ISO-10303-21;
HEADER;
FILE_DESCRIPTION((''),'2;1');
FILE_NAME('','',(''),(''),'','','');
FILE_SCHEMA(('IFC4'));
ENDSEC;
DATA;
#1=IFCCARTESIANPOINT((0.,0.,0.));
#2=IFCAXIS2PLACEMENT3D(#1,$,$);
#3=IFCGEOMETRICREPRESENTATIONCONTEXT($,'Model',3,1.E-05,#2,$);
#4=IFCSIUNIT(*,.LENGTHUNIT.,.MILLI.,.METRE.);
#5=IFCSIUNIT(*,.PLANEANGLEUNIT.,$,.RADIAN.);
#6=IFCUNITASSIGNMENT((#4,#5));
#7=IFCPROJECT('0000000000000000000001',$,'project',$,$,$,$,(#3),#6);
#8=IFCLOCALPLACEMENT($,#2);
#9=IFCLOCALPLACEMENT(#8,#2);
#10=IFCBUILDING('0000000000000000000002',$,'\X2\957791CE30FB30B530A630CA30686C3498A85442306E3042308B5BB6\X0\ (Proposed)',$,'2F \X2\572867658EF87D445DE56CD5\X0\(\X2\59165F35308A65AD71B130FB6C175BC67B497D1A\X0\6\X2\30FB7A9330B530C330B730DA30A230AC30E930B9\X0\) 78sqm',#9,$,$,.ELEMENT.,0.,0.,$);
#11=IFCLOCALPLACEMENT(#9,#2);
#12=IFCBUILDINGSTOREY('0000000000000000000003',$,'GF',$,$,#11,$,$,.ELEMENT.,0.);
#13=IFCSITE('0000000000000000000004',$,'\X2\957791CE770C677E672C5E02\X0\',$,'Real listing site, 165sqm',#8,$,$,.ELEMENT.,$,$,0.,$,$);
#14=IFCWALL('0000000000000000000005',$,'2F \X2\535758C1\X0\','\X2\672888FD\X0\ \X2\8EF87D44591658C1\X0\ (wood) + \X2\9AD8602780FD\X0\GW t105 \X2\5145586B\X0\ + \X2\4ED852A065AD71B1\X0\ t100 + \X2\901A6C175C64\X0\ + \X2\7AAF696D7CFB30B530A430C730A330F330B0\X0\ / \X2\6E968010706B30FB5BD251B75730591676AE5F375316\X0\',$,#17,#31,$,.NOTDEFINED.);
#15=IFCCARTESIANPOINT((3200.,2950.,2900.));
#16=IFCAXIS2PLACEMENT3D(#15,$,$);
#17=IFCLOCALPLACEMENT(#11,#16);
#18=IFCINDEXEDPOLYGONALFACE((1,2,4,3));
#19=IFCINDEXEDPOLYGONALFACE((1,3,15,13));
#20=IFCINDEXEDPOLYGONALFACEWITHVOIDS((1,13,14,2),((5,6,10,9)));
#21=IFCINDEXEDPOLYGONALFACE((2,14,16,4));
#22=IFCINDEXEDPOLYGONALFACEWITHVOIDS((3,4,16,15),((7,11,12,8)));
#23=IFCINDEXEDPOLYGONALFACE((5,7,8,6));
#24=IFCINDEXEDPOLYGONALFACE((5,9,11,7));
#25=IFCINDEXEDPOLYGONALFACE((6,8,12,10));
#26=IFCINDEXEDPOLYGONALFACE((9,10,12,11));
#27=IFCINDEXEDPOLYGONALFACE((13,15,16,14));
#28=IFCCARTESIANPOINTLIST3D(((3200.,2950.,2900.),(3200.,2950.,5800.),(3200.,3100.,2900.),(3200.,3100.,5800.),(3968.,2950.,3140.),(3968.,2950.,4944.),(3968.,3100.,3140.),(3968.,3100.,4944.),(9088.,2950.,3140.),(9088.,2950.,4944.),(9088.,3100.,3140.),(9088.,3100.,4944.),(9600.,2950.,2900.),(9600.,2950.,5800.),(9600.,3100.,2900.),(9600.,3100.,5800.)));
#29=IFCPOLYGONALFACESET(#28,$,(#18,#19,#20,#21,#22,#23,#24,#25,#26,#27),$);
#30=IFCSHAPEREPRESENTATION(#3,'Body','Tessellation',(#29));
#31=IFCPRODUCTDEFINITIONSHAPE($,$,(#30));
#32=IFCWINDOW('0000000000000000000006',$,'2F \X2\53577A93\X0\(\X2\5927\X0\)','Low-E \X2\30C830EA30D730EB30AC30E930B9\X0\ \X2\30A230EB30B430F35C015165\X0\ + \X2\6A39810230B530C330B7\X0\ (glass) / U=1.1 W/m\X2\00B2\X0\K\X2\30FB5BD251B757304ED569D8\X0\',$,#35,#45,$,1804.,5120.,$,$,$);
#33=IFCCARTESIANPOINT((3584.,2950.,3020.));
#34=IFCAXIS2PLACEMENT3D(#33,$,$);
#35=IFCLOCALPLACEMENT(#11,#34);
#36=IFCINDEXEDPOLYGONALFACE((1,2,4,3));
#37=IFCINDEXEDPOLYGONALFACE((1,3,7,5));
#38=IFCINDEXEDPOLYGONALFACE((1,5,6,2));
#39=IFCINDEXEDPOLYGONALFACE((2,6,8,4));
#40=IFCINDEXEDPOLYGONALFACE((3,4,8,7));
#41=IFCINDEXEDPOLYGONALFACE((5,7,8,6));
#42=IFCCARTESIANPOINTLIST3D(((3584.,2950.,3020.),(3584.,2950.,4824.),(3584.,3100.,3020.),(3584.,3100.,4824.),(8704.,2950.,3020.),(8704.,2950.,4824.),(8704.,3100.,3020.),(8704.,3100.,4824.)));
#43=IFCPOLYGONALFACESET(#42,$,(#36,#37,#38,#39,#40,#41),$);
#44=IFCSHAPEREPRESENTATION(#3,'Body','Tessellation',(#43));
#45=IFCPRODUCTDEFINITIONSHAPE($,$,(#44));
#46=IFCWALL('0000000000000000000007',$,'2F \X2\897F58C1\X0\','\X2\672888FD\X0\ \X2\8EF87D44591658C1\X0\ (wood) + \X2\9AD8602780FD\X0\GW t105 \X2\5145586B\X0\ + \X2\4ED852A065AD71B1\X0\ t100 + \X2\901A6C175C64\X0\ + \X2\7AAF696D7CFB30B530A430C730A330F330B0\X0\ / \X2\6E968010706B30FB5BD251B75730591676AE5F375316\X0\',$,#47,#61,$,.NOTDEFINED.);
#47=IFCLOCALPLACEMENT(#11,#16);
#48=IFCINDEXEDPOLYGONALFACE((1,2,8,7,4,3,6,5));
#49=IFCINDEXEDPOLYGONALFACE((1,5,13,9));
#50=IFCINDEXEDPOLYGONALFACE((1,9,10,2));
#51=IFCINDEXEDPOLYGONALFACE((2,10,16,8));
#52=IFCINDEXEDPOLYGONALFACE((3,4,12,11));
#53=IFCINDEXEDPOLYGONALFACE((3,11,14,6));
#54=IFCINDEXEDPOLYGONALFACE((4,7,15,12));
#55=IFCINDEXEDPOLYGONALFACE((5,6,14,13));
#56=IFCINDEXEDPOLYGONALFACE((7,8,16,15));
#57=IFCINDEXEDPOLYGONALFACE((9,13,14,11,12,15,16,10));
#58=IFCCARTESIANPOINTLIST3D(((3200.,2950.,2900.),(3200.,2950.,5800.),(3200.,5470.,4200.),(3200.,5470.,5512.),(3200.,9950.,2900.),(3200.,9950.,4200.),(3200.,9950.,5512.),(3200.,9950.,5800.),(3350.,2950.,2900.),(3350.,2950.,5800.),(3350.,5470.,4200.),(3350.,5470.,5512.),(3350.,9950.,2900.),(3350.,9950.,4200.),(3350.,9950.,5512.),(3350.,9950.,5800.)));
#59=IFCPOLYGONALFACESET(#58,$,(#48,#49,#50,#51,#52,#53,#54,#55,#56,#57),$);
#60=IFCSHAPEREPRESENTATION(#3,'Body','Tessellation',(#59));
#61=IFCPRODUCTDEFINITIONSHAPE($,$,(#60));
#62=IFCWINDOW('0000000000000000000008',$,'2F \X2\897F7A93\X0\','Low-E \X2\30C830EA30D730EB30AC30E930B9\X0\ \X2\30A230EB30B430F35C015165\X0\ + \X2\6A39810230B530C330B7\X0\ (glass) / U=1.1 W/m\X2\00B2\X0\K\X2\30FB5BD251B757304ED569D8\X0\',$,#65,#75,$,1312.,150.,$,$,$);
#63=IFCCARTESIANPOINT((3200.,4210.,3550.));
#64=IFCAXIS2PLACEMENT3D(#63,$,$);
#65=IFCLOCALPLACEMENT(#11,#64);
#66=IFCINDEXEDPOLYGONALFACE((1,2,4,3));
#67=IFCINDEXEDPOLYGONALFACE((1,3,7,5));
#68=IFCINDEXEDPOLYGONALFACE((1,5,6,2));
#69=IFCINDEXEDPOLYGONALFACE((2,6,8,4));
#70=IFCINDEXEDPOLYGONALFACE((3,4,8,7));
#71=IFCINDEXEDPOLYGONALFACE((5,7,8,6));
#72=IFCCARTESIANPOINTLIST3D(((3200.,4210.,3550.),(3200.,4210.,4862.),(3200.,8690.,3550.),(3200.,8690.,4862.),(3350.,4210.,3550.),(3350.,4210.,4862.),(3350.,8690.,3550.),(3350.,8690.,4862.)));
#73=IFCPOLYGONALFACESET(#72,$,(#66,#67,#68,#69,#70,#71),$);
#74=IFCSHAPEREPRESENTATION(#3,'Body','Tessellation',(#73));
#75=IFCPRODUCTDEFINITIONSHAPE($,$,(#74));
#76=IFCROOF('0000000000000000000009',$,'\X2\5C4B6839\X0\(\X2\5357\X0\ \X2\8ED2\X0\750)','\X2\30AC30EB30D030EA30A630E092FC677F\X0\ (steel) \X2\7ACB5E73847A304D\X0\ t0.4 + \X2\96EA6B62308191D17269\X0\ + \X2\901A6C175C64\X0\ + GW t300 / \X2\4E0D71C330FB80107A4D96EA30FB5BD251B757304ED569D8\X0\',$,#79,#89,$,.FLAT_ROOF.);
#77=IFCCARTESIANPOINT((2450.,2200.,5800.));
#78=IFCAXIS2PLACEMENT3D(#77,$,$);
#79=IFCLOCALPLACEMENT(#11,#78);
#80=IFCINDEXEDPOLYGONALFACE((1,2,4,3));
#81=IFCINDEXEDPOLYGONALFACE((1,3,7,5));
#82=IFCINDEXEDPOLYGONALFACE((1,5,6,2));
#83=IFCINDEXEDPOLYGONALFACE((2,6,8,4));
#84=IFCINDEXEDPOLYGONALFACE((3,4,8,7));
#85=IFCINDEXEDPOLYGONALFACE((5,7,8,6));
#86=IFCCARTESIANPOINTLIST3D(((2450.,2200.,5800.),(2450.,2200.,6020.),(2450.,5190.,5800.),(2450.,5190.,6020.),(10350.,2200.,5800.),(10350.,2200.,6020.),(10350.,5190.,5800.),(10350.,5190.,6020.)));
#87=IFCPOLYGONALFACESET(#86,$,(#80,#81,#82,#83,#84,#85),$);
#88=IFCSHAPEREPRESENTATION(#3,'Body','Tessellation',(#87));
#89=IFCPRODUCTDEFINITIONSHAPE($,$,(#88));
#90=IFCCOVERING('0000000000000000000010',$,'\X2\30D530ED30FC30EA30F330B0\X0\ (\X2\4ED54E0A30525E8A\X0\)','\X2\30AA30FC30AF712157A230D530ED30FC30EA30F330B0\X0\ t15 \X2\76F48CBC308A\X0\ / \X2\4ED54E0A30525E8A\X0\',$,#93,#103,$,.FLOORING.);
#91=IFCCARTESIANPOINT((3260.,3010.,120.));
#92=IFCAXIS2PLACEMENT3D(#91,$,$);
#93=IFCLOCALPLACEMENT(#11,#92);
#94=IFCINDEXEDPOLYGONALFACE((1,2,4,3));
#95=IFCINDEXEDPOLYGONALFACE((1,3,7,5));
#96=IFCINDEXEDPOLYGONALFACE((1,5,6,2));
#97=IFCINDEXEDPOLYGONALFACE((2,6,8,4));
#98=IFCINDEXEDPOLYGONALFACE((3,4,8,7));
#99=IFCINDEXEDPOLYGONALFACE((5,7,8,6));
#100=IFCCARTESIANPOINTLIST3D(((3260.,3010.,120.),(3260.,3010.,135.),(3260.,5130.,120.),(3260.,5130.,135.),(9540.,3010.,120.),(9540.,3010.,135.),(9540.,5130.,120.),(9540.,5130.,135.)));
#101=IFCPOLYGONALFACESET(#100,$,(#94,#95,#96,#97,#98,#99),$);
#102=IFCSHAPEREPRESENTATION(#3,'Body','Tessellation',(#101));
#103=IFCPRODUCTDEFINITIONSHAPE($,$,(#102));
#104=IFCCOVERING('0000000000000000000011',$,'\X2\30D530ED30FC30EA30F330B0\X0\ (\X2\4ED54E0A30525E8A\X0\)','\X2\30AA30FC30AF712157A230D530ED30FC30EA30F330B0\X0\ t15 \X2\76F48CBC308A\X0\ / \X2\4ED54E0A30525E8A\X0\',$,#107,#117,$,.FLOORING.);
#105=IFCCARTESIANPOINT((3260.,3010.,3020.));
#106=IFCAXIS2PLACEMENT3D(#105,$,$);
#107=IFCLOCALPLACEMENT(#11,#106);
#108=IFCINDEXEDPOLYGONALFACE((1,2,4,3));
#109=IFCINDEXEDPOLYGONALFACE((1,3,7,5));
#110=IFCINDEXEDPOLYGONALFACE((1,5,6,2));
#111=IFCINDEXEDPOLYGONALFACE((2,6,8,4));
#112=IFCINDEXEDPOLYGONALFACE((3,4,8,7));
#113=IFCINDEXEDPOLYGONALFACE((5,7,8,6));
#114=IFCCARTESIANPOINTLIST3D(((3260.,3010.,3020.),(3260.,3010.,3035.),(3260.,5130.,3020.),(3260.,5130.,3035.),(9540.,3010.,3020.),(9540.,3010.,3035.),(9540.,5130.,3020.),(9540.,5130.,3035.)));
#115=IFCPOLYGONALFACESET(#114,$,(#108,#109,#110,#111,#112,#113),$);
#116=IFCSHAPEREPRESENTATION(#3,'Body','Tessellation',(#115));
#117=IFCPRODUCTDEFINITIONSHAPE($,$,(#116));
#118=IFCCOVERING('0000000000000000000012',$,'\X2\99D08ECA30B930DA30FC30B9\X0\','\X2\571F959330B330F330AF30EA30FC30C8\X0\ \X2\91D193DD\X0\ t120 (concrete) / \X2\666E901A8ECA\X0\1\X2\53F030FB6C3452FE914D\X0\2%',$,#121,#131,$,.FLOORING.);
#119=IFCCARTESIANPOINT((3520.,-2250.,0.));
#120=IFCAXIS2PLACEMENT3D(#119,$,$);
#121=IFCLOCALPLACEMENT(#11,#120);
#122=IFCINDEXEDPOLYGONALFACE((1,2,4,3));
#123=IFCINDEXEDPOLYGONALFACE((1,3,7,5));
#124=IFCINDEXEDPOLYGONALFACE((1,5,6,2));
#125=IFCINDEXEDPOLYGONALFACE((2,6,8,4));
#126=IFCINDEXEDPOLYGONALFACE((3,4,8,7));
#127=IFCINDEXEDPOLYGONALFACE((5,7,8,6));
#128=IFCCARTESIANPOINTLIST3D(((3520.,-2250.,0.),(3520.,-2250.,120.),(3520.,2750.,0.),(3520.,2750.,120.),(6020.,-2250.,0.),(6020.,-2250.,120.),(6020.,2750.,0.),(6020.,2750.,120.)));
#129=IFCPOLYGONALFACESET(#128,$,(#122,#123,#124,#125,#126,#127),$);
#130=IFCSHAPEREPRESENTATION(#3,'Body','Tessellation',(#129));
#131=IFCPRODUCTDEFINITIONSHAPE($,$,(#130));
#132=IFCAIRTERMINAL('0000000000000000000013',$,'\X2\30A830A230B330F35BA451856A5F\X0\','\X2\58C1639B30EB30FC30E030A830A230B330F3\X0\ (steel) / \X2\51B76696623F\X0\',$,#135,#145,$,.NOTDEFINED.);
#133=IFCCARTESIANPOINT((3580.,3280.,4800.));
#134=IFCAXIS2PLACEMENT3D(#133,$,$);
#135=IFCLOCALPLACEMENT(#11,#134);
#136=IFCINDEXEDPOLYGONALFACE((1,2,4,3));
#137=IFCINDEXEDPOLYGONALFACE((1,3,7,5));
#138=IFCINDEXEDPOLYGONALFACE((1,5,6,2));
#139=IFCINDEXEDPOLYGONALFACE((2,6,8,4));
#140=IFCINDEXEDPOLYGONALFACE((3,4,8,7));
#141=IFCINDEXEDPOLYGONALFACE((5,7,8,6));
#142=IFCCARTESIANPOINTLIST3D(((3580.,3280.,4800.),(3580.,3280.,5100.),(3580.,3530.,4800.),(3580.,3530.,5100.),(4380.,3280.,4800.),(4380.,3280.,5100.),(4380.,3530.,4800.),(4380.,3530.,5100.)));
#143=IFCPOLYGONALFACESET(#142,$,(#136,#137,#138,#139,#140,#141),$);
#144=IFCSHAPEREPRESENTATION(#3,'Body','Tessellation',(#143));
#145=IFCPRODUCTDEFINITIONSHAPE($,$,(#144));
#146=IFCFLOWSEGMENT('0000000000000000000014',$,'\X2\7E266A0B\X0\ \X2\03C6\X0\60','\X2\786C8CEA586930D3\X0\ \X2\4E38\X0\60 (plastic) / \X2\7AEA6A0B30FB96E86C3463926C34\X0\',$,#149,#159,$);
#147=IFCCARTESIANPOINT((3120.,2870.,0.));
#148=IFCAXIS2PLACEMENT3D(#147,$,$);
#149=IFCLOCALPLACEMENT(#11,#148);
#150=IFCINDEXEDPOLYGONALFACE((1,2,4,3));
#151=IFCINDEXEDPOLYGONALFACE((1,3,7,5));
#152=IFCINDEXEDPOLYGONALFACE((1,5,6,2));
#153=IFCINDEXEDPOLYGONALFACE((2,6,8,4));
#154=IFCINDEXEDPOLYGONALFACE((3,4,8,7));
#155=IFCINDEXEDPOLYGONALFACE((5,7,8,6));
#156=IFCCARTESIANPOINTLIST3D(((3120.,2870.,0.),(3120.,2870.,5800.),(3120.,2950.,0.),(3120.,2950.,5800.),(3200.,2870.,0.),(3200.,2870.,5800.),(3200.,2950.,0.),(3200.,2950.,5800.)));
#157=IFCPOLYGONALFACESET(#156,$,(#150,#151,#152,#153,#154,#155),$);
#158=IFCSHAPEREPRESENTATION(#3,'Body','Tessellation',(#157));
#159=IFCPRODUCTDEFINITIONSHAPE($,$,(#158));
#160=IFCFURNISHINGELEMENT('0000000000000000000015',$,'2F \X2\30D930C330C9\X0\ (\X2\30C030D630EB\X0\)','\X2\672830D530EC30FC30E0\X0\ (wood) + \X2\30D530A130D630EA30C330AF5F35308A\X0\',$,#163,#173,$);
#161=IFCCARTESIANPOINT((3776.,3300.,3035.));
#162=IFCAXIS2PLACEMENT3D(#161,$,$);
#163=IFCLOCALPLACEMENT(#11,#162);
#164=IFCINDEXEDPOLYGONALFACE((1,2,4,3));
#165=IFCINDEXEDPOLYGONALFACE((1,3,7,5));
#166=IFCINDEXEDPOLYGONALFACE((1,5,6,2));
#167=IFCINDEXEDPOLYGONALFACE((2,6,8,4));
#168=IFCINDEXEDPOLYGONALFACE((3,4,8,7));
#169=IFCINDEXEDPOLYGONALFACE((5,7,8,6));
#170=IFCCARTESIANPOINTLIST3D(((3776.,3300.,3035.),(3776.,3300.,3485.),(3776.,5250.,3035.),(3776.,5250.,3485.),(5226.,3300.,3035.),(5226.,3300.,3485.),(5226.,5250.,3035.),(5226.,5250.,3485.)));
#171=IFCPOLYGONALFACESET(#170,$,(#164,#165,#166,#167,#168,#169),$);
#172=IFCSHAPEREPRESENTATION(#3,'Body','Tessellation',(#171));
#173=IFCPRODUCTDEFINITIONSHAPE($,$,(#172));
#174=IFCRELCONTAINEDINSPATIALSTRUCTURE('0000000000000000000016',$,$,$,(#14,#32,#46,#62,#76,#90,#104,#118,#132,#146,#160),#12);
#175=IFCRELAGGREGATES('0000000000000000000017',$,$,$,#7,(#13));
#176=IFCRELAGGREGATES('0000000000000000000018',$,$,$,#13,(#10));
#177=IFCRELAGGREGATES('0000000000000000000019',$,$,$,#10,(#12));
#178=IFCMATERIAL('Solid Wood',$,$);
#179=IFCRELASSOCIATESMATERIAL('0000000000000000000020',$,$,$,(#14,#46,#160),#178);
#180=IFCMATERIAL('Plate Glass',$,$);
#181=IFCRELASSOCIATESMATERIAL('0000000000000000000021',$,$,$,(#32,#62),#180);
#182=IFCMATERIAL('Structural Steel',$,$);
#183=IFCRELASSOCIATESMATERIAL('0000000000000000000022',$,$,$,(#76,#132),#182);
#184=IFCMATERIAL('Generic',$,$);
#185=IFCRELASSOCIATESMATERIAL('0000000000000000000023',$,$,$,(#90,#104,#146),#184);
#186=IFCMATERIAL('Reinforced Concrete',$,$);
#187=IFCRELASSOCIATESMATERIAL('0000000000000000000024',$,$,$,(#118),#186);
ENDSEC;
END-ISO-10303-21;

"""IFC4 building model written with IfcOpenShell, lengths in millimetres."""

from ifc_helpers import new_model, si_unit, frame, frame_2d, origin, place, context, project, spatial, rectangle, extrude, material, element, fill, save


model = new_model("IFC4")

# Units and contexts
model_context = context("Model", 3, precision=1e-05, world=origin())
ifc_project = project(units=[si_unit("LENGTHUNIT", "METRE", prefix="MILLI"), si_unit("PLANEANGLEUNIT", "RADIAN")], contexts=[model_context])

# Site, building, storey
site_placement = place(None, origin())
site = spatial("IfcSite", under=ifc_project, at=site_placement, Name="長野県松本市", ObjectType="Real listing site, 165sqm", CompositionType="ELEMENT", RefElevation=0.0)
building_placement = place(site_placement, origin())
building = spatial("IfcBuilding", under=site, at=building_placement, Name="長野・サウナと水風呂のある家 (Proposed)", ObjectType="2F 在来軸組工法(外張り断熱・気密等級6・窓サッシペアガラス) 78sqm", CompositionType="ELEMENT", ElevationOfRefHeight=0.0, ElevationOfTerrain=0.0)
storey_placement = place(building_placement, origin())
storey = spatial("IfcBuildingStorey", under=building, at=storey_placement, Name="GF", CompositionType="ELEMENT", Elevation=0.0)

# Shared definitions
ifc_material_1 = material(Name="Solid Wood")

# Shared definitions
ifc_material_2 = material(Name="Reinforced Concrete")

# Shared definitions
ifc_material_3 = material(Name="Plate Glass")

# Walls, openings, windows
wall_1_placement = place(storey_placement, frame((3200.0, 2950.0, 2900.0)))
wall_1 = element("IfcWall", 1, at=wall_1_placement, inside=storey, material=ifc_material_1, Name="2F 南壁", Description="木製 軸組外壁 (wood) + 高性能GW t105 充填 + 付加断熱 t100 + 通気層 + 窯業系サイディング / 準耐火・寒冷地外皮強化", PredefinedType="NOTDEFINED", context=model_context, shape_type="SweptSolid", body=[
    extrude(rectangle(XDim=6400.0, YDim=150.0, at=frame_2d((3200.0, 75.0))), frame((3200.0, 2950.0, 2900.0)), (0.0, 0.0, 1.0), 2900.0),
])
opening_1_placement = place(storey_placement, frame((3584.0, 2950.0, 3020.0)))
opening_1 = element("IfcOpeningElement", 2, at=opening_1_placement, cuts=wall_1, PredefinedType="NOTDEFINED", context=model_context, shape_type="SweptSolid", body=[
    extrude(rectangle(XDim=5120.0, YDim=150.0, at=frame_2d((2560.0, 75.0))), frame((3584.0, 2950.0, 3020.0)), (0.0, 0.0, 1.0), 1804.0),
])
window_1_placement = place(storey_placement, frame((3584.0, 2950.0, 3020.0)))
window_1 = element("IfcWindow", 3, at=window_1_placement, inside=storey, material=ifc_material_3, Name="2F 南窓(大)", Description="Low-E トリプルガラス アルゴン封入 + 樹脂サッシ (glass) / U=1.1 W/m²K・寒冷地仕様", OverallHeight=1804.0, OverallWidth=5120.0, context=model_context, shape_type="SweptSolid", body=[
    extrude(rectangle(XDim=5120.0, YDim=150.0, at=frame_2d((2560.0, 75.0))), frame((3584.0, 2950.0, 3020.0)), (0.0, 0.0, 1.0), 1804.0),
])
fill(opening_1, window_1)
wall_2_placement = place(storey_placement, frame((3200.0, 2950.0, 2900.0)))
wall_2 = element("IfcWall", 4, at=wall_2_placement, inside=storey, material=ifc_material_1, Name="2F 西壁", Description="木製 軸組外壁 (wood) + 高性能GW t105 充填 + 付加断熱 t100 + 通気層 + 窯業系サイディング / 準耐火・寒冷地外皮強化", PredefinedType="NOTDEFINED", context=model_context, shape_type="SweptSolid", body=[
    extrude(rectangle(XDim=150.0, YDim=7000.0, at=frame_2d((75.0, 3500.0))), frame((3200.0, 2950.0, 2900.0)), (0.0, 0.0, 1.0), 2900.0),
])
opening_2_placement = place(storey_placement, frame((3200.0, 4210.0, 3550.0)))
opening_2 = element("IfcOpeningElement", 5, at=opening_2_placement, cuts=wall_2, PredefinedType="NOTDEFINED", context=model_context, shape_type="SweptSolid", body=[
    extrude(rectangle(XDim=150.0, YDim=4480.0, at=frame_2d((75.0, 2240.0))), frame((3200.0, 4210.0, 3550.0)), (0.0, 0.0, 1.0), 1312.0),
])
window_2_placement = place(storey_placement, frame((3200.0, 4210.0, 3550.0)))
window_2 = element("IfcWindow", 6, at=window_2_placement, inside=storey, material=ifc_material_3, Name="2F 西窓", Description="Low-E トリプルガラス アルゴン封入 + 樹脂サッシ (glass) / U=1.1 W/m²K・寒冷地仕様", OverallHeight=1312.0, OverallWidth=150.0, context=model_context, shape_type="SweptSolid", body=[
    extrude(rectangle(XDim=150.0, YDim=4480.0, at=frame_2d((75.0, 2240.0))), frame((3200.0, 4210.0, 3550.0)), (0.0, 0.0, 1.0), 1312.0),
])
fill(opening_2, window_2)

# Roof
ifc_material_4 = material(Name="Structural Steel")
for number, where, name in (
    (7, (2450.0, 2200.0, 5800.0), "屋根(南 軒750)"),
):
    element("IfcRoof", number, at=place(storey_placement, frame(where)), inside=storey, material=ifc_material_4, Name=name, Description="ガルバリウム鋼板 (steel) 立平葺き t0.4 + 雪止め金物 + 通気層 + GW t300 / 不燃・耐積雪・寒冷地仕様", PredefinedType="FLAT_ROOF", context=model_context, shape_type="SweptSolid", body=[
        extrude(rectangle(XDim=7900.0, YDim=2990.0, at=frame_2d((3950.0, 1495.0))), frame((2450.0, 2200.0, 5800.0)), (0.0, 0.0, 1.0), 220.0),
    ])

# Coverings
ifc_material_5 = material(Name="Generic")
covering_1_placement = place(storey_placement, frame((3260.0, 3010.0, 120.0)))
element("IfcCovering", 8, at=covering_1_placement, inside=storey, material=ifc_material_5, Name="フローリング (仕上げ床)", Description="オーク無垢フローリング t15 直貼り / 仕上げ床", PredefinedType="FLOORING", context=model_context, shape_type="SweptSolid", body=[
    extrude(rectangle(XDim=6280.0, YDim=2120.0, at=frame_2d((3140.0, 1060.0))), frame((3260.0, 3010.0, 120.0)), (0.0, 0.0, 1.0), 15.0),
])
covering_2_placement = place(storey_placement, frame((3260.0, 3010.0, 3020.0)))
element("IfcCovering", 9, at=covering_2_placement, inside=storey, material=ifc_material_5, Name="フローリング (仕上げ床)", Description="オーク無垢フローリング t15 直貼り / 仕上げ床", PredefinedType="FLOORING", context=model_context, shape_type="SweptSolid", body=[
    extrude(rectangle(XDim=6280.0, YDim=2120.0, at=frame_2d((3140.0, 1060.0))), frame((3260.0, 3010.0, 3020.0)), (0.0, 0.0, 1.0), 15.0),
])
covering_3_placement = place(storey_placement, frame((3520.0, -2250.0, 0.0)))
element("IfcCovering", 10, at=covering_3_placement, inside=storey, material=ifc_material_2, Name="駐車スペース", Description="土間コンクリート 金鏝 t120 (concrete) / 普通車1台・水勾配2%", PredefinedType="FLOORING", context=model_context, shape_type="SweptSolid", body=[
    extrude(rectangle(XDim=2500.0, YDim=5000.0, at=frame_2d((1250.0, 2500.0))), frame((3520.0, -2250.0, 0.0)), (0.0, 0.0, 1.0), 120.0),
])

# Air terminal
air_terminal_placement = place(storey_placement, frame((3580.0, 3280.0, 4800.0)))
element("IfcAirTerminal", 11, at=air_terminal_placement, inside=storey, material=ifc_material_4, Name="エアコン室内機", Description="壁掛ルームエアコン (steel) / 冷暖房", PredefinedType="NOTDEFINED", context=model_context, shape_type="SweptSolid", body=[
    extrude(rectangle(XDim=800.0, YDim=250.0, at=frame_2d((400.0, 125.0))), frame((3580.0, 3280.0, 4800.0)), (0.0, 0.0, 1.0), 300.0),
])

# Flow segment
flow_segment_1_placement = place(storey_placement, frame((3120.0, 2870.0, 0.0)))
element("IfcFlowSegment", 12, at=flow_segment_1_placement, inside=storey, material=ifc_material_5, Name="縦樋 φ60", Description="硬質塩ビ 丸60 (plastic) / 竪樋・雨水排水", context=model_context, shape_type="SweptSolid", body=[
    extrude(rectangle(XDim=80.0, YDim=80.0, at=frame_2d((40.0, 40.0))), frame((3120.0, 2870.0, 0.0)), (0.0, 0.0, 1.0), 5800.0),
])

# Furnishing element
furnishing_placement = place(storey_placement, frame((3776.0, 3300.0, 3035.0)))
element("IfcFurnishingElement", 13, at=furnishing_placement, inside=storey, material=ifc_material_1, Name="2F ベッド (ダブル)", Description="木フレーム (wood) + ファブリック張り", context=model_context, shape_type="SweptSolid", body=[
    extrude(rectangle(XDim=1450.0, YDim=1950.0, at=frame_2d((725.0, 975.0))), frame((3776.0, 3300.0, 3035.0)), (0.0, 0.0, 1.0), 450.0),
])

save(model, "model.ifc")
